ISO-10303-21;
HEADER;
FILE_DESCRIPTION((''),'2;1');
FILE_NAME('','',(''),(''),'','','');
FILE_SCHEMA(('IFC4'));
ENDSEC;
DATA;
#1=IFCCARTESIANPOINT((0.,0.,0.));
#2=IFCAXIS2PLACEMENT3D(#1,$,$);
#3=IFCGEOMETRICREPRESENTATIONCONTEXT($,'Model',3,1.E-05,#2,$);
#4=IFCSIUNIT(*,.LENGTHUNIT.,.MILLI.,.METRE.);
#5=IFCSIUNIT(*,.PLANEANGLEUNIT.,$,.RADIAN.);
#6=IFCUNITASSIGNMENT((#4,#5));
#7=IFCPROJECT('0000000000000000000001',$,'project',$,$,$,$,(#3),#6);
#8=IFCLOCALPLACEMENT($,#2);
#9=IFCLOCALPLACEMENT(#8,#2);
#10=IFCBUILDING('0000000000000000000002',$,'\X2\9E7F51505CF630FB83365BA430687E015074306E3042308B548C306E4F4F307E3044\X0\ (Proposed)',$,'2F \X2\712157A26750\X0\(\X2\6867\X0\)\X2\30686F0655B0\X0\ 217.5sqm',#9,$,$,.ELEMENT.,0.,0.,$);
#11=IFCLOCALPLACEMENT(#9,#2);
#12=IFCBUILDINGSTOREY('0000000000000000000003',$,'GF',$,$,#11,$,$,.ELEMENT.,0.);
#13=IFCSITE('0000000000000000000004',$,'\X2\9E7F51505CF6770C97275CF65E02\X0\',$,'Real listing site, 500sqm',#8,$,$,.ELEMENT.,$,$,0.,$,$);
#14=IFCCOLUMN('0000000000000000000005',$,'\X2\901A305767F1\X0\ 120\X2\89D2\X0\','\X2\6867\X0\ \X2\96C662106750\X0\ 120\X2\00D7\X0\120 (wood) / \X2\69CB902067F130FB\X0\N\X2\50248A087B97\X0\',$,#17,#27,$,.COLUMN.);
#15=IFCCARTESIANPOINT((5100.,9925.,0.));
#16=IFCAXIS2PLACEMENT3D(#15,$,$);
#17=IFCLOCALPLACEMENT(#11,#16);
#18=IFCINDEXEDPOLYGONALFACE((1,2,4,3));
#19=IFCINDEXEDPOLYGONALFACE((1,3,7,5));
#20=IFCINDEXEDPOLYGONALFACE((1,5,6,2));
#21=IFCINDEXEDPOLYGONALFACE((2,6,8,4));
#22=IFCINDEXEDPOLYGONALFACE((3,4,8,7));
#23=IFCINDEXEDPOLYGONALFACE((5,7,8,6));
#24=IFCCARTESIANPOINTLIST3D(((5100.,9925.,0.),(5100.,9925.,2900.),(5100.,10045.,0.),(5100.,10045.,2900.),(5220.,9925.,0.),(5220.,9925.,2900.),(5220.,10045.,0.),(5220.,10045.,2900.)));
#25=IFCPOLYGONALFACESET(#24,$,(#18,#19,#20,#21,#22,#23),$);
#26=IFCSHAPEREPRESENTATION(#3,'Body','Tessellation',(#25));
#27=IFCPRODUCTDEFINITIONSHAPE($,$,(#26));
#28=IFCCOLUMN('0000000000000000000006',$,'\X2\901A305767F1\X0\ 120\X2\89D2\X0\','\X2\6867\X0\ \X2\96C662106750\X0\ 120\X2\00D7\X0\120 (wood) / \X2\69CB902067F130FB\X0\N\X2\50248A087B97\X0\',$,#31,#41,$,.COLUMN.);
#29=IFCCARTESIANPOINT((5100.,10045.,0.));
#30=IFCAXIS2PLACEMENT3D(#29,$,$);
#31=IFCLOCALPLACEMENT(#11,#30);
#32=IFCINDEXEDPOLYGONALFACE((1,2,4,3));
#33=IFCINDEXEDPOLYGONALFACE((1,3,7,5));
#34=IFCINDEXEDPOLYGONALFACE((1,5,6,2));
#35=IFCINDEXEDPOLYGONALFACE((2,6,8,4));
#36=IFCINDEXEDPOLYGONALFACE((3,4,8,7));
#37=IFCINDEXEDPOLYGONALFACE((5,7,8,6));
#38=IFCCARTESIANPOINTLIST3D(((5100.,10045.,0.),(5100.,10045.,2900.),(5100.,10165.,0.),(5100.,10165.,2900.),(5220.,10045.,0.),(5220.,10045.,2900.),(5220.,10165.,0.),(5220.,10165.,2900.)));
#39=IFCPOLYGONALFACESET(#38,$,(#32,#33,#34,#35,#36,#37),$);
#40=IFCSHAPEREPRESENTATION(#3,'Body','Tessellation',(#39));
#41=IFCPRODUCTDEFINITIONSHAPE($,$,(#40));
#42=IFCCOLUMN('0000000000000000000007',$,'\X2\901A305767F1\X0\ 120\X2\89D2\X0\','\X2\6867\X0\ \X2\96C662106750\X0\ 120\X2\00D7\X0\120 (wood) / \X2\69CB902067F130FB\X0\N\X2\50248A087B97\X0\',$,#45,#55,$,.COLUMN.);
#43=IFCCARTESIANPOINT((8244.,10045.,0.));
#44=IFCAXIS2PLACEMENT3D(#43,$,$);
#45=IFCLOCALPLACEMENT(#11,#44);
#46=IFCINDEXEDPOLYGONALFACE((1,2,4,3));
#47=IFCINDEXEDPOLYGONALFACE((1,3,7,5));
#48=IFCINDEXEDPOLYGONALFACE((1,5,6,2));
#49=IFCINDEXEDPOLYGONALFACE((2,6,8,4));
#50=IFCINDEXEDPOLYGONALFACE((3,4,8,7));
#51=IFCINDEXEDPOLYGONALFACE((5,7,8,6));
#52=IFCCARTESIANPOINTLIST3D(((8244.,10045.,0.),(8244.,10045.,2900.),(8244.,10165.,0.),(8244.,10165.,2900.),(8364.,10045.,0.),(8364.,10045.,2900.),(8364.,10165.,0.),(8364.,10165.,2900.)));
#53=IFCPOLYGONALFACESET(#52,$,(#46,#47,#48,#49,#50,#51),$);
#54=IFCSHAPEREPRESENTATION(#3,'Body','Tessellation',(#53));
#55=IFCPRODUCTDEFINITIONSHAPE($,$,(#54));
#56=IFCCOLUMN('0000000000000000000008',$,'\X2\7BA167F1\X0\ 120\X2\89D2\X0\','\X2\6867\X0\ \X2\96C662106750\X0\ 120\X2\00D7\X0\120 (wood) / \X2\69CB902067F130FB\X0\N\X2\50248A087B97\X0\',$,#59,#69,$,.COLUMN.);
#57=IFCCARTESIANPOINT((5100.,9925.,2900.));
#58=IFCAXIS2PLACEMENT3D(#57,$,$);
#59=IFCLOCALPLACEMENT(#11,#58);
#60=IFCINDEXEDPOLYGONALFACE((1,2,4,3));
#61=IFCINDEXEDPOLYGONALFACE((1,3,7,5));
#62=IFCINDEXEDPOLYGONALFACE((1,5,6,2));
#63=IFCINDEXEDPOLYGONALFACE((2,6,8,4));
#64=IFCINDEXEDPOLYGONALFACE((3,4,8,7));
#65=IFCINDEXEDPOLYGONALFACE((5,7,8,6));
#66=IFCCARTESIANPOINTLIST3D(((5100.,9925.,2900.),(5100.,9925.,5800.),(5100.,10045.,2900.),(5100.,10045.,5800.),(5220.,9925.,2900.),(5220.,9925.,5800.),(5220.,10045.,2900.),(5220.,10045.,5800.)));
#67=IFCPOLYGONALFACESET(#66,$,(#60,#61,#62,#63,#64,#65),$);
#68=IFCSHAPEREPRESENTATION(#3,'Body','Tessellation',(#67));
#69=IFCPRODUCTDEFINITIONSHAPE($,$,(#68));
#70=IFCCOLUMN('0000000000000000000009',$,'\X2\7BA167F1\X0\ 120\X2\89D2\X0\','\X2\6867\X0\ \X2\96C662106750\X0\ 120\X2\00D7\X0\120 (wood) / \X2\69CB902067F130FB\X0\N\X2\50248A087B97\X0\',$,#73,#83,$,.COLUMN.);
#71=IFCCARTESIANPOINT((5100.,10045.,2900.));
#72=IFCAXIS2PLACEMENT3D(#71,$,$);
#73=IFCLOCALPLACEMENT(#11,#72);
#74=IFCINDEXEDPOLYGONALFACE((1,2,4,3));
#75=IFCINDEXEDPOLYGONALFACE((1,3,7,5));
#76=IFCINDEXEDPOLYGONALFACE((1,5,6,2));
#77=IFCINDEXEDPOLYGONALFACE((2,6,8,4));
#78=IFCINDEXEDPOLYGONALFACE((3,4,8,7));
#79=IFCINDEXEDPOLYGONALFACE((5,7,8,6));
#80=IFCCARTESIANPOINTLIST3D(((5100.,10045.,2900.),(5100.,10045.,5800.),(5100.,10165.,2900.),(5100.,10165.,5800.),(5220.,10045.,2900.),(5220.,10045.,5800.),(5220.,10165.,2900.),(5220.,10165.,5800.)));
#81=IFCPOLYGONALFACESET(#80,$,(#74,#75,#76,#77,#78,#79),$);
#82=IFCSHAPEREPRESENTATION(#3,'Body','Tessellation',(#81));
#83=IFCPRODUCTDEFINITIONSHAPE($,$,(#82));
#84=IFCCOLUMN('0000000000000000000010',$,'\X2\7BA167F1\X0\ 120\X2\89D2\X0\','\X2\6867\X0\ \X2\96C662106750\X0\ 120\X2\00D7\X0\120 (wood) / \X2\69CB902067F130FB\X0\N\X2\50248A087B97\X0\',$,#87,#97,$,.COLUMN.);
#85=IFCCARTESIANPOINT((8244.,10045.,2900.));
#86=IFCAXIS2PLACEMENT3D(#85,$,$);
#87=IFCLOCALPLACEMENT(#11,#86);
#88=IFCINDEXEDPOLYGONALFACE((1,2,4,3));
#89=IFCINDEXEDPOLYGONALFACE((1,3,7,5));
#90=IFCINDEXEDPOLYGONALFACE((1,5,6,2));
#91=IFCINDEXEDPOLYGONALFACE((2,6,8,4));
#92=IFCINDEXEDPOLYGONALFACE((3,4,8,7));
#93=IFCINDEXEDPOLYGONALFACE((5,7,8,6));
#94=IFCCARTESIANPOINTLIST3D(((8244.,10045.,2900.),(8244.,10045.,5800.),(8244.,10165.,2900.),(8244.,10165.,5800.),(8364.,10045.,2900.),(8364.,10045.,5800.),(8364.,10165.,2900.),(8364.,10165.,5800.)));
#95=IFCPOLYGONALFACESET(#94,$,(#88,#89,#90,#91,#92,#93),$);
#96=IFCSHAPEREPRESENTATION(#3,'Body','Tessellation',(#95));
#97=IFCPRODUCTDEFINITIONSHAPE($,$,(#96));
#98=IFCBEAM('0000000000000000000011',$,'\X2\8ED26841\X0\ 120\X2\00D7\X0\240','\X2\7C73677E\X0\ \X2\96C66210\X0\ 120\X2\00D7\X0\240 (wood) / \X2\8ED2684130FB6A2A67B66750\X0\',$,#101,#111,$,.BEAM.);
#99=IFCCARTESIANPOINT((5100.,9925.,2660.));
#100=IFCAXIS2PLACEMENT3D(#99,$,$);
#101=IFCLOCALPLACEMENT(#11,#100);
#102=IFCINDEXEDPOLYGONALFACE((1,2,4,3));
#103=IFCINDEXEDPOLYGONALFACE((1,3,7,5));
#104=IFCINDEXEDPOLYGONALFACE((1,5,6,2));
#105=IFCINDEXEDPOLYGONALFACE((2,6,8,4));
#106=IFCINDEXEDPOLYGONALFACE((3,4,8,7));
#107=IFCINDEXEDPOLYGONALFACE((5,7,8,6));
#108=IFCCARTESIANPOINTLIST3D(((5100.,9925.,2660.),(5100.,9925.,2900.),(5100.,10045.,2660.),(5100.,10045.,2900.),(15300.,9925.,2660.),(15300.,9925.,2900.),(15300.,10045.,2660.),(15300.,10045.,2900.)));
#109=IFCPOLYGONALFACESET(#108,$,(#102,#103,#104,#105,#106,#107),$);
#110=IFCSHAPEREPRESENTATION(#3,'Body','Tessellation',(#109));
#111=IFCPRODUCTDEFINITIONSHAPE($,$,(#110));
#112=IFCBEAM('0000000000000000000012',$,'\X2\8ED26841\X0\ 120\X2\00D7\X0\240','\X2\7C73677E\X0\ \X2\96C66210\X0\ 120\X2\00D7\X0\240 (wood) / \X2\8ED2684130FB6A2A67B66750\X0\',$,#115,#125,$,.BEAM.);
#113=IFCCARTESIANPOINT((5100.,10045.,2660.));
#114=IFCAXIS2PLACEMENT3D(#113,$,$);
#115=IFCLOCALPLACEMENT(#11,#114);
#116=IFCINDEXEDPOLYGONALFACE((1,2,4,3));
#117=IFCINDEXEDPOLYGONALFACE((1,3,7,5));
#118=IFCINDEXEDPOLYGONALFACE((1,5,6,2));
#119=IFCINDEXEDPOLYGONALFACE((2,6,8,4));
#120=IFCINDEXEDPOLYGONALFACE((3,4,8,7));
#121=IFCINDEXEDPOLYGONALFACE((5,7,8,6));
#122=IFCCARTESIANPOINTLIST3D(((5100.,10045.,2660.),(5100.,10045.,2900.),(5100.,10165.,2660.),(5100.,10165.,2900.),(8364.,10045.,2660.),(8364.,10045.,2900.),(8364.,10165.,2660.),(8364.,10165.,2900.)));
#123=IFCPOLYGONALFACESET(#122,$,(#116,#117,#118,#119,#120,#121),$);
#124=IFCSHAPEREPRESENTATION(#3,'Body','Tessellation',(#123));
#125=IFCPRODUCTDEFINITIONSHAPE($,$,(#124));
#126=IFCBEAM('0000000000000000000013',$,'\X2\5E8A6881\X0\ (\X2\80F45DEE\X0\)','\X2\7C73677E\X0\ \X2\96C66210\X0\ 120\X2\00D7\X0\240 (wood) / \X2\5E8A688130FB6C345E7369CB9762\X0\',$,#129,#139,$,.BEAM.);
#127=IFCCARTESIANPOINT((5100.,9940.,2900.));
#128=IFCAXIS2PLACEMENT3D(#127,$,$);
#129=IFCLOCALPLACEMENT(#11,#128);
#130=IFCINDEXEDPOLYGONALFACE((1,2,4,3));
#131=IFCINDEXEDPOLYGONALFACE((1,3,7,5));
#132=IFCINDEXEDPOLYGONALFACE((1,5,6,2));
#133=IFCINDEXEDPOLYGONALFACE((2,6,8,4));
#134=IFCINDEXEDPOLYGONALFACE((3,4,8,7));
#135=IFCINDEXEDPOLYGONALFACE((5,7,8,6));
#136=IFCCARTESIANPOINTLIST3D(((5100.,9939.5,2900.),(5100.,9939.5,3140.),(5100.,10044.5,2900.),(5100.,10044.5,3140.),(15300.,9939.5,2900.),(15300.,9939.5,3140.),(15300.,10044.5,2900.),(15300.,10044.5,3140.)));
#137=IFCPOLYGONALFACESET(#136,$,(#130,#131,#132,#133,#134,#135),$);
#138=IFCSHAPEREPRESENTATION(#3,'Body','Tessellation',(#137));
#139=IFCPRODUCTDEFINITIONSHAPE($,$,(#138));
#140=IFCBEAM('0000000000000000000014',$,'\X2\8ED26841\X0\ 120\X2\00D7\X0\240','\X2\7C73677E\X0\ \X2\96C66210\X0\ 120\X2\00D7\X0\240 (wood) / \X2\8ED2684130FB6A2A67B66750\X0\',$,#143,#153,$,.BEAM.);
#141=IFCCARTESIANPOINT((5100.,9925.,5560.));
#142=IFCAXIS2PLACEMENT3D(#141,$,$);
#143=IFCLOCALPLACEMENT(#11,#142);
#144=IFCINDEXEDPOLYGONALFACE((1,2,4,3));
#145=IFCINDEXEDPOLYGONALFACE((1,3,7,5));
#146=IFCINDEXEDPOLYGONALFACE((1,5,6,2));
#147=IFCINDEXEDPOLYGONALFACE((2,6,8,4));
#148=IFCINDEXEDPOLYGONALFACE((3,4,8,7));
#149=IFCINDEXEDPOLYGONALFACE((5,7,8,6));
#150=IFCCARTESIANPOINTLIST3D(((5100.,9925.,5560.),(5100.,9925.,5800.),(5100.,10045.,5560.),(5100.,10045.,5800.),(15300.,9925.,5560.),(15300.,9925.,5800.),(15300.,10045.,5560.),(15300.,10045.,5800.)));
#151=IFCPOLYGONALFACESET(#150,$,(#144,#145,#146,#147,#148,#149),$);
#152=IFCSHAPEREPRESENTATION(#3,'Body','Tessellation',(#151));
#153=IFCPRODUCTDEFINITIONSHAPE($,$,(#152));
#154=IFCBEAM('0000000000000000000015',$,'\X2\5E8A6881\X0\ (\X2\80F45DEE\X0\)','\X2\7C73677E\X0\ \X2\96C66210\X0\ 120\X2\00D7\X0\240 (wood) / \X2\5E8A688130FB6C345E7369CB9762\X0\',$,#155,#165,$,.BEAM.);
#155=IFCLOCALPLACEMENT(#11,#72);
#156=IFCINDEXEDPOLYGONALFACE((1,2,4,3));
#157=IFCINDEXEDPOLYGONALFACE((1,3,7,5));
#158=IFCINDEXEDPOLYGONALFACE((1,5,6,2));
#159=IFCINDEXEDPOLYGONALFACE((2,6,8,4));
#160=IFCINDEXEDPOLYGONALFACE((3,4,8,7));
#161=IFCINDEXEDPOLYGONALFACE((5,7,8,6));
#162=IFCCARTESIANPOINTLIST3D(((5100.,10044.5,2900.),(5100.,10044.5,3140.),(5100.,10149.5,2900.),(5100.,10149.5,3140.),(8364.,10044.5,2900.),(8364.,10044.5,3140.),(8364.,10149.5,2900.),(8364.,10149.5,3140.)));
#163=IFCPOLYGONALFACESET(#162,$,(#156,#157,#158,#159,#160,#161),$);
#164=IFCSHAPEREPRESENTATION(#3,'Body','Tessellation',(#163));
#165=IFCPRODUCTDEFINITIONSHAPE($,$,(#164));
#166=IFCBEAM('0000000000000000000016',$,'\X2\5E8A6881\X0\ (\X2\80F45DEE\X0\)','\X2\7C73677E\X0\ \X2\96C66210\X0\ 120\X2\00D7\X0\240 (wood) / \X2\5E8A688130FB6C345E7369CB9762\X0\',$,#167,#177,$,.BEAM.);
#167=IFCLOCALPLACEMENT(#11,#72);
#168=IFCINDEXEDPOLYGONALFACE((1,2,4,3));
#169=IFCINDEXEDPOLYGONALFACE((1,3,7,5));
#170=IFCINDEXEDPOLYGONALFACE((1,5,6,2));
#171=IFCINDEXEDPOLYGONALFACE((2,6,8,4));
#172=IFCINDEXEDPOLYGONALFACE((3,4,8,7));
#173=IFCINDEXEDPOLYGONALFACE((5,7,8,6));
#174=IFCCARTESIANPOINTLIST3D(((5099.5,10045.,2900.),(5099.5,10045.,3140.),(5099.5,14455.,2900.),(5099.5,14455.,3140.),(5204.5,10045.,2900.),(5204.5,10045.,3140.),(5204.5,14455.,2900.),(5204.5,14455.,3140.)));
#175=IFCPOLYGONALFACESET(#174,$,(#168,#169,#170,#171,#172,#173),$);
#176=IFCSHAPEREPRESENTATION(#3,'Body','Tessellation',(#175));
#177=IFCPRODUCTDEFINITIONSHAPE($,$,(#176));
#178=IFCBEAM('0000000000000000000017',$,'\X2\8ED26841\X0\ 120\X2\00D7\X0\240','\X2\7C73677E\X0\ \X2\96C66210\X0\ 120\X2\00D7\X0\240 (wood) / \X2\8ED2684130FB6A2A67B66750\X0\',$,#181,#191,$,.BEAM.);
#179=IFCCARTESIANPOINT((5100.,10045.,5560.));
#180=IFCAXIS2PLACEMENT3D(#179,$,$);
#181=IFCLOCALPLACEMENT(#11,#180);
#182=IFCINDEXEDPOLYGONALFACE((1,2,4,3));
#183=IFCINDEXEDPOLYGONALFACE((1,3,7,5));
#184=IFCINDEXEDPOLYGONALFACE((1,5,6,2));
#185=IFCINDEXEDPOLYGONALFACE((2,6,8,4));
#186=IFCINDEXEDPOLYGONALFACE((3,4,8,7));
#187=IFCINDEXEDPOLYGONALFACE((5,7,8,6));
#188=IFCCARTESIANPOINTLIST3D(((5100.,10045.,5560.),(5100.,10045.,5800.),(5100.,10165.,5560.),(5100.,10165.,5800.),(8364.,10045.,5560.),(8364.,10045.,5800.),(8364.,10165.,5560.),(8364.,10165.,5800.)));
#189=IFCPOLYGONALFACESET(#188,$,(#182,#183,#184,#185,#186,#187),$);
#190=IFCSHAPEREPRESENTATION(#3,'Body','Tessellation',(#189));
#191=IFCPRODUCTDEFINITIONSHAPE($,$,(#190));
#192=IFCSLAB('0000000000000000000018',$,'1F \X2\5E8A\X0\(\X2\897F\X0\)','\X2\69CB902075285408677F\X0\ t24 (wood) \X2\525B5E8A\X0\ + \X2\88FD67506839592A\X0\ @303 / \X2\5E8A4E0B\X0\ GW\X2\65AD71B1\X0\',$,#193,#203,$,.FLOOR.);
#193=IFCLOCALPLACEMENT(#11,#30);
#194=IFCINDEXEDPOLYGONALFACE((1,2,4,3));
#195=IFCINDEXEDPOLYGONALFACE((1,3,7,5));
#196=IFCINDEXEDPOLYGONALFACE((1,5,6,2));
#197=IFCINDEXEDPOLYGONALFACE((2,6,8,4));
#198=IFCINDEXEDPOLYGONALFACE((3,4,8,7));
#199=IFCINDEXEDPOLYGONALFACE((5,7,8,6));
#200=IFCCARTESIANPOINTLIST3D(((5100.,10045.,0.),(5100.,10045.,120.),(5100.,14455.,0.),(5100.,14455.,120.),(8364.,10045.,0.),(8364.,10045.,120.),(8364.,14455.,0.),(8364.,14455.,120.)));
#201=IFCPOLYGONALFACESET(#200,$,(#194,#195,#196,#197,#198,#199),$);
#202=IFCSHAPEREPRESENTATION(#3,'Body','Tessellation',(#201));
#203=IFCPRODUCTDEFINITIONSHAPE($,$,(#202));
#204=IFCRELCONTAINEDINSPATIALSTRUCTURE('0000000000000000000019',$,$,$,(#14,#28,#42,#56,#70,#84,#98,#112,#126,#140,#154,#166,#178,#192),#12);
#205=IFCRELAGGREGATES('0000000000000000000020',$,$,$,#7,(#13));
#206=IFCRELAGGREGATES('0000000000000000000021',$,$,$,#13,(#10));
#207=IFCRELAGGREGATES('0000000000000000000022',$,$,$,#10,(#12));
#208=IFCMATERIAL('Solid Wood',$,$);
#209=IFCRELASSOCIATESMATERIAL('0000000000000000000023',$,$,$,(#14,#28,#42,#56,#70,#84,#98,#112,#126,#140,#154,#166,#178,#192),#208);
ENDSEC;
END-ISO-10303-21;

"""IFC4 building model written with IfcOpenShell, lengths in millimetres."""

from ifc_helpers import new_model, si_unit, frame, frame_2d, origin, place, context, project, spatial, rectangle, extrude, material, element, save


model = new_model("IFC4")

# Units and contexts
model_context = context("Model", 3, precision=1e-05, world=origin())
ifc_project = project(units=[si_unit("LENGTHUNIT", "METRE", prefix="MILLI"), si_unit("PLANEANGLEUNIT", "RADIAN")], contexts=[model_context])

# Site, building, storey
site_placement = place(None, origin())
site = spatial("IfcSite", under=ifc_project, at=site_placement, Name="鹿児島県霧島市", ObjectType="Real listing site, 500sqm", CompositionType="ELEMENT", RefElevation=0.0)
building_placement = place(site_placement, origin())
building = spatial("IfcBuilding", under=site, at=building_placement, Name="鹿児島・茶室と縁側のある和の住まい (Proposed)", ObjectType="2F 無垢材(桧)と漆喰 217.5sqm", CompositionType="ELEMENT", ElevationOfRefHeight=0.0, ElevationOfTerrain=0.0)
storey_placement = place(building_placement, origin())
storey = spatial("IfcBuildingStorey", under=building, at=storey_placement, Name="GF", CompositionType="ELEMENT", Elevation=0.0)

# Columns
ifc_material_1 = material(Name="Solid Wood")
column_1_placement = place(storey_placement, frame((5100.0, 9925.0, 0.0)))
element("IfcColumn", 1, at=column_1_placement, inside=storey, material=ifc_material_1, Name="通し柱 120角", Description="桧 集成材 120×120 (wood) / 構造柱・N値計算", PredefinedType="COLUMN", context=model_context, shape_type="SweptSolid", body=[
    extrude(rectangle(XDim=120.0, YDim=120.0, at=frame_2d((60.0, 60.0))), frame((5100.0, 9925.0, 0.0)), (0.0, 0.0, 1.0), 2900.0),
])
column_2_placement = place(storey_placement, frame((5100.0, 10045.0, 0.0)))
element("IfcColumn", 2, at=column_2_placement, inside=storey, material=ifc_material_1, Name="通し柱 120角", Description="桧 集成材 120×120 (wood) / 構造柱・N値計算", PredefinedType="COLUMN", context=model_context, shape_type="SweptSolid", body=[
    extrude(rectangle(XDim=120.0, YDim=120.0, at=frame_2d((60.0, 60.0))), frame((5100.0, 10045.0, 0.0)), (0.0, 0.0, 1.0), 2900.0),
])
column_3_placement = place(storey_placement, frame((8244.0, 10045.0, 0.0)))
element("IfcColumn", 3, at=column_3_placement, inside=storey, material=ifc_material_1, Name="通し柱 120角", Description="桧 集成材 120×120 (wood) / 構造柱・N値計算", PredefinedType="COLUMN", context=model_context, shape_type="SweptSolid", body=[
    extrude(rectangle(XDim=120.0, YDim=120.0, at=frame_2d((60.0, 60.0))), frame((8244.0, 10045.0, 0.0)), (0.0, 0.0, 1.0), 2900.0),
])
column_4_placement = place(storey_placement, frame((5100.0, 9925.0, 2900.0)))
element("IfcColumn", 4, at=column_4_placement, inside=storey, material=ifc_material_1, Name="管柱 120角", Description="桧 集成材 120×120 (wood) / 構造柱・N値計算", PredefinedType="COLUMN", context=model_context, shape_type="SweptSolid", body=[
    extrude(rectangle(XDim=120.0, YDim=120.0, at=frame_2d((60.0, 60.0))), frame((5100.0, 9925.0, 2900.0)), (0.0, 0.0, 1.0), 2900.0),
])
column_5_placement = place(storey_placement, frame((5100.0, 10045.0, 2900.0)))
element("IfcColumn", 5, at=column_5_placement, inside=storey, material=ifc_material_1, Name="管柱 120角", Description="桧 集成材 120×120 (wood) / 構造柱・N値計算", PredefinedType="COLUMN", context=model_context, shape_type="SweptSolid", body=[
    extrude(rectangle(XDim=120.0, YDim=120.0, at=frame_2d((60.0, 60.0))), frame((5100.0, 10045.0, 2900.0)), (0.0, 0.0, 1.0), 2900.0),
])
column_6_placement = place(storey_placement, frame((8244.0, 10045.0, 2900.0)))
element("IfcColumn", 6, at=column_6_placement, inside=storey, material=ifc_material_1, Name="管柱 120角", Description="桧 集成材 120×120 (wood) / 構造柱・N値計算", PredefinedType="COLUMN", context=model_context, shape_type="SweptSolid", body=[
    extrude(rectangle(XDim=120.0, YDim=120.0, at=frame_2d((60.0, 60.0))), frame((8244.0, 10045.0, 2900.0)), (0.0, 0.0, 1.0), 2900.0),
])

# Beams
beam_1_placement = place(storey_placement, frame((5100.0, 9925.0, 2660.0)))
element("IfcBeam", 7, at=beam_1_placement, inside=storey, material=ifc_material_1, Name="軒桁 120×240", Description="米松 集成 120×240 (wood) / 軒桁・横架材", PredefinedType="BEAM", context=model_context, shape_type="SweptSolid", body=[
    extrude(rectangle(XDim=10200.0, YDim=120.0, at=frame_2d((5100.0, 60.0))), frame((5100.0, 9925.0, 2660.0)), (0.0, 0.0, 1.0), 240.0),
])
beam_2_placement = place(storey_placement, frame((5100.0, 10045.0, 2660.0)))
element("IfcBeam", 8, at=beam_2_placement, inside=storey, material=ifc_material_1, Name="軒桁 120×240", Description="米松 集成 120×240 (wood) / 軒桁・横架材", PredefinedType="BEAM", context=model_context, shape_type="SweptSolid", body=[
    extrude(rectangle(XDim=3264.0, YDim=120.0, at=frame_2d((1632.0, 60.0))), frame((5100.0, 10045.0, 2660.0)), (0.0, 0.0, 1.0), 240.0),
])
beam_3_placement = place(storey_placement, frame((5100.0, 9940.0, 2900.0)))
element("IfcBeam", 9, at=beam_3_placement, inside=storey, material=ifc_material_1, Name="床梁 (胴差)", Description="米松 集成 120×240 (wood) / 床梁・水平構面", PredefinedType="BEAM", context=model_context, shape_type="SweptSolid", body=[
    extrude(rectangle(XDim=10200.0, YDim=105.0, at=frame_2d((5100.0, 52.0))), frame((5100.0, 9940.0, 2900.0)), (0.0, 0.0, 1.0), 240.0),
])
beam_4_placement = place(storey_placement, frame((5100.0, 9925.0, 5560.0)))
element("IfcBeam", 10, at=beam_4_placement, inside=storey, material=ifc_material_1, Name="軒桁 120×240", Description="米松 集成 120×240 (wood) / 軒桁・横架材", PredefinedType="BEAM", context=model_context, shape_type="SweptSolid", body=[
    extrude(rectangle(XDim=10200.0, YDim=120.0, at=frame_2d((5100.0, 60.0))), frame((5100.0, 9925.0, 5560.0)), (0.0, 0.0, 1.0), 240.0),
])
beam_5_placement = place(storey_placement, frame((5100.0, 10045.0, 2900.0)))
element("IfcBeam", 11, at=beam_5_placement, inside=storey, material=ifc_material_1, Name="床梁 (胴差)", Description="米松 集成 120×240 (wood) / 床梁・水平構面", PredefinedType="BEAM", context=model_context, shape_type="SweptSolid", body=[
    extrude(rectangle(XDim=3264.0, YDim=105.0, at=frame_2d((1632.0, 52.0))), frame((5100.0, 10045.0, 2900.0)), (0.0, 0.0, 1.0), 240.0),
])
beam_6_placement = place(storey_placement, frame((5100.0, 10045.0, 2900.0)))
element("IfcBeam", 12, at=beam_6_placement, inside=storey, material=ifc_material_1, Name="床梁 (胴差)", Description="米松 集成 120×240 (wood) / 床梁・水平構面", PredefinedType="BEAM", context=model_context, shape_type="SweptSolid", body=[
    extrude(rectangle(XDim=105.0, YDim=4410.0, at=frame_2d((52.0, 2205.0))), frame((5100.0, 10045.0, 2900.0)), (0.0, 0.0, 1.0), 240.0),
])
beam_7_placement = place(storey_placement, frame((5100.0, 10045.0, 5560.0)))
element("IfcBeam", 13, at=beam_7_placement, inside=storey, material=ifc_material_1, Name="軒桁 120×240", Description="米松 集成 120×240 (wood) / 軒桁・横架材", PredefinedType="BEAM", context=model_context, shape_type="SweptSolid", body=[
    extrude(rectangle(XDim=3264.0, YDim=120.0, at=frame_2d((1632.0, 60.0))), frame((5100.0, 10045.0, 5560.0)), (0.0, 0.0, 1.0), 240.0),
])

# Slab
slab_1_placement = place(storey_placement, frame((5100.0, 10045.0, 0.0)))
element("IfcSlab", 14, at=slab_1_placement, inside=storey, material=ifc_material_1, Name="1F 床(西)", Description="構造用合板 t24 (wood) 剛床 + 製材根太 @303 / 床下 GW断熱", PredefinedType="FLOOR", context=model_context, shape_type="SweptSolid", body=[
    extrude(rectangle(XDim=3264.0, YDim=4410.0, at=frame_2d((1632.0, 2205.0))), frame((5100.0, 10045.0, 0.0)), (0.0, 0.0, 1.0), 120.0),
])

save(model, "model.ifc")
